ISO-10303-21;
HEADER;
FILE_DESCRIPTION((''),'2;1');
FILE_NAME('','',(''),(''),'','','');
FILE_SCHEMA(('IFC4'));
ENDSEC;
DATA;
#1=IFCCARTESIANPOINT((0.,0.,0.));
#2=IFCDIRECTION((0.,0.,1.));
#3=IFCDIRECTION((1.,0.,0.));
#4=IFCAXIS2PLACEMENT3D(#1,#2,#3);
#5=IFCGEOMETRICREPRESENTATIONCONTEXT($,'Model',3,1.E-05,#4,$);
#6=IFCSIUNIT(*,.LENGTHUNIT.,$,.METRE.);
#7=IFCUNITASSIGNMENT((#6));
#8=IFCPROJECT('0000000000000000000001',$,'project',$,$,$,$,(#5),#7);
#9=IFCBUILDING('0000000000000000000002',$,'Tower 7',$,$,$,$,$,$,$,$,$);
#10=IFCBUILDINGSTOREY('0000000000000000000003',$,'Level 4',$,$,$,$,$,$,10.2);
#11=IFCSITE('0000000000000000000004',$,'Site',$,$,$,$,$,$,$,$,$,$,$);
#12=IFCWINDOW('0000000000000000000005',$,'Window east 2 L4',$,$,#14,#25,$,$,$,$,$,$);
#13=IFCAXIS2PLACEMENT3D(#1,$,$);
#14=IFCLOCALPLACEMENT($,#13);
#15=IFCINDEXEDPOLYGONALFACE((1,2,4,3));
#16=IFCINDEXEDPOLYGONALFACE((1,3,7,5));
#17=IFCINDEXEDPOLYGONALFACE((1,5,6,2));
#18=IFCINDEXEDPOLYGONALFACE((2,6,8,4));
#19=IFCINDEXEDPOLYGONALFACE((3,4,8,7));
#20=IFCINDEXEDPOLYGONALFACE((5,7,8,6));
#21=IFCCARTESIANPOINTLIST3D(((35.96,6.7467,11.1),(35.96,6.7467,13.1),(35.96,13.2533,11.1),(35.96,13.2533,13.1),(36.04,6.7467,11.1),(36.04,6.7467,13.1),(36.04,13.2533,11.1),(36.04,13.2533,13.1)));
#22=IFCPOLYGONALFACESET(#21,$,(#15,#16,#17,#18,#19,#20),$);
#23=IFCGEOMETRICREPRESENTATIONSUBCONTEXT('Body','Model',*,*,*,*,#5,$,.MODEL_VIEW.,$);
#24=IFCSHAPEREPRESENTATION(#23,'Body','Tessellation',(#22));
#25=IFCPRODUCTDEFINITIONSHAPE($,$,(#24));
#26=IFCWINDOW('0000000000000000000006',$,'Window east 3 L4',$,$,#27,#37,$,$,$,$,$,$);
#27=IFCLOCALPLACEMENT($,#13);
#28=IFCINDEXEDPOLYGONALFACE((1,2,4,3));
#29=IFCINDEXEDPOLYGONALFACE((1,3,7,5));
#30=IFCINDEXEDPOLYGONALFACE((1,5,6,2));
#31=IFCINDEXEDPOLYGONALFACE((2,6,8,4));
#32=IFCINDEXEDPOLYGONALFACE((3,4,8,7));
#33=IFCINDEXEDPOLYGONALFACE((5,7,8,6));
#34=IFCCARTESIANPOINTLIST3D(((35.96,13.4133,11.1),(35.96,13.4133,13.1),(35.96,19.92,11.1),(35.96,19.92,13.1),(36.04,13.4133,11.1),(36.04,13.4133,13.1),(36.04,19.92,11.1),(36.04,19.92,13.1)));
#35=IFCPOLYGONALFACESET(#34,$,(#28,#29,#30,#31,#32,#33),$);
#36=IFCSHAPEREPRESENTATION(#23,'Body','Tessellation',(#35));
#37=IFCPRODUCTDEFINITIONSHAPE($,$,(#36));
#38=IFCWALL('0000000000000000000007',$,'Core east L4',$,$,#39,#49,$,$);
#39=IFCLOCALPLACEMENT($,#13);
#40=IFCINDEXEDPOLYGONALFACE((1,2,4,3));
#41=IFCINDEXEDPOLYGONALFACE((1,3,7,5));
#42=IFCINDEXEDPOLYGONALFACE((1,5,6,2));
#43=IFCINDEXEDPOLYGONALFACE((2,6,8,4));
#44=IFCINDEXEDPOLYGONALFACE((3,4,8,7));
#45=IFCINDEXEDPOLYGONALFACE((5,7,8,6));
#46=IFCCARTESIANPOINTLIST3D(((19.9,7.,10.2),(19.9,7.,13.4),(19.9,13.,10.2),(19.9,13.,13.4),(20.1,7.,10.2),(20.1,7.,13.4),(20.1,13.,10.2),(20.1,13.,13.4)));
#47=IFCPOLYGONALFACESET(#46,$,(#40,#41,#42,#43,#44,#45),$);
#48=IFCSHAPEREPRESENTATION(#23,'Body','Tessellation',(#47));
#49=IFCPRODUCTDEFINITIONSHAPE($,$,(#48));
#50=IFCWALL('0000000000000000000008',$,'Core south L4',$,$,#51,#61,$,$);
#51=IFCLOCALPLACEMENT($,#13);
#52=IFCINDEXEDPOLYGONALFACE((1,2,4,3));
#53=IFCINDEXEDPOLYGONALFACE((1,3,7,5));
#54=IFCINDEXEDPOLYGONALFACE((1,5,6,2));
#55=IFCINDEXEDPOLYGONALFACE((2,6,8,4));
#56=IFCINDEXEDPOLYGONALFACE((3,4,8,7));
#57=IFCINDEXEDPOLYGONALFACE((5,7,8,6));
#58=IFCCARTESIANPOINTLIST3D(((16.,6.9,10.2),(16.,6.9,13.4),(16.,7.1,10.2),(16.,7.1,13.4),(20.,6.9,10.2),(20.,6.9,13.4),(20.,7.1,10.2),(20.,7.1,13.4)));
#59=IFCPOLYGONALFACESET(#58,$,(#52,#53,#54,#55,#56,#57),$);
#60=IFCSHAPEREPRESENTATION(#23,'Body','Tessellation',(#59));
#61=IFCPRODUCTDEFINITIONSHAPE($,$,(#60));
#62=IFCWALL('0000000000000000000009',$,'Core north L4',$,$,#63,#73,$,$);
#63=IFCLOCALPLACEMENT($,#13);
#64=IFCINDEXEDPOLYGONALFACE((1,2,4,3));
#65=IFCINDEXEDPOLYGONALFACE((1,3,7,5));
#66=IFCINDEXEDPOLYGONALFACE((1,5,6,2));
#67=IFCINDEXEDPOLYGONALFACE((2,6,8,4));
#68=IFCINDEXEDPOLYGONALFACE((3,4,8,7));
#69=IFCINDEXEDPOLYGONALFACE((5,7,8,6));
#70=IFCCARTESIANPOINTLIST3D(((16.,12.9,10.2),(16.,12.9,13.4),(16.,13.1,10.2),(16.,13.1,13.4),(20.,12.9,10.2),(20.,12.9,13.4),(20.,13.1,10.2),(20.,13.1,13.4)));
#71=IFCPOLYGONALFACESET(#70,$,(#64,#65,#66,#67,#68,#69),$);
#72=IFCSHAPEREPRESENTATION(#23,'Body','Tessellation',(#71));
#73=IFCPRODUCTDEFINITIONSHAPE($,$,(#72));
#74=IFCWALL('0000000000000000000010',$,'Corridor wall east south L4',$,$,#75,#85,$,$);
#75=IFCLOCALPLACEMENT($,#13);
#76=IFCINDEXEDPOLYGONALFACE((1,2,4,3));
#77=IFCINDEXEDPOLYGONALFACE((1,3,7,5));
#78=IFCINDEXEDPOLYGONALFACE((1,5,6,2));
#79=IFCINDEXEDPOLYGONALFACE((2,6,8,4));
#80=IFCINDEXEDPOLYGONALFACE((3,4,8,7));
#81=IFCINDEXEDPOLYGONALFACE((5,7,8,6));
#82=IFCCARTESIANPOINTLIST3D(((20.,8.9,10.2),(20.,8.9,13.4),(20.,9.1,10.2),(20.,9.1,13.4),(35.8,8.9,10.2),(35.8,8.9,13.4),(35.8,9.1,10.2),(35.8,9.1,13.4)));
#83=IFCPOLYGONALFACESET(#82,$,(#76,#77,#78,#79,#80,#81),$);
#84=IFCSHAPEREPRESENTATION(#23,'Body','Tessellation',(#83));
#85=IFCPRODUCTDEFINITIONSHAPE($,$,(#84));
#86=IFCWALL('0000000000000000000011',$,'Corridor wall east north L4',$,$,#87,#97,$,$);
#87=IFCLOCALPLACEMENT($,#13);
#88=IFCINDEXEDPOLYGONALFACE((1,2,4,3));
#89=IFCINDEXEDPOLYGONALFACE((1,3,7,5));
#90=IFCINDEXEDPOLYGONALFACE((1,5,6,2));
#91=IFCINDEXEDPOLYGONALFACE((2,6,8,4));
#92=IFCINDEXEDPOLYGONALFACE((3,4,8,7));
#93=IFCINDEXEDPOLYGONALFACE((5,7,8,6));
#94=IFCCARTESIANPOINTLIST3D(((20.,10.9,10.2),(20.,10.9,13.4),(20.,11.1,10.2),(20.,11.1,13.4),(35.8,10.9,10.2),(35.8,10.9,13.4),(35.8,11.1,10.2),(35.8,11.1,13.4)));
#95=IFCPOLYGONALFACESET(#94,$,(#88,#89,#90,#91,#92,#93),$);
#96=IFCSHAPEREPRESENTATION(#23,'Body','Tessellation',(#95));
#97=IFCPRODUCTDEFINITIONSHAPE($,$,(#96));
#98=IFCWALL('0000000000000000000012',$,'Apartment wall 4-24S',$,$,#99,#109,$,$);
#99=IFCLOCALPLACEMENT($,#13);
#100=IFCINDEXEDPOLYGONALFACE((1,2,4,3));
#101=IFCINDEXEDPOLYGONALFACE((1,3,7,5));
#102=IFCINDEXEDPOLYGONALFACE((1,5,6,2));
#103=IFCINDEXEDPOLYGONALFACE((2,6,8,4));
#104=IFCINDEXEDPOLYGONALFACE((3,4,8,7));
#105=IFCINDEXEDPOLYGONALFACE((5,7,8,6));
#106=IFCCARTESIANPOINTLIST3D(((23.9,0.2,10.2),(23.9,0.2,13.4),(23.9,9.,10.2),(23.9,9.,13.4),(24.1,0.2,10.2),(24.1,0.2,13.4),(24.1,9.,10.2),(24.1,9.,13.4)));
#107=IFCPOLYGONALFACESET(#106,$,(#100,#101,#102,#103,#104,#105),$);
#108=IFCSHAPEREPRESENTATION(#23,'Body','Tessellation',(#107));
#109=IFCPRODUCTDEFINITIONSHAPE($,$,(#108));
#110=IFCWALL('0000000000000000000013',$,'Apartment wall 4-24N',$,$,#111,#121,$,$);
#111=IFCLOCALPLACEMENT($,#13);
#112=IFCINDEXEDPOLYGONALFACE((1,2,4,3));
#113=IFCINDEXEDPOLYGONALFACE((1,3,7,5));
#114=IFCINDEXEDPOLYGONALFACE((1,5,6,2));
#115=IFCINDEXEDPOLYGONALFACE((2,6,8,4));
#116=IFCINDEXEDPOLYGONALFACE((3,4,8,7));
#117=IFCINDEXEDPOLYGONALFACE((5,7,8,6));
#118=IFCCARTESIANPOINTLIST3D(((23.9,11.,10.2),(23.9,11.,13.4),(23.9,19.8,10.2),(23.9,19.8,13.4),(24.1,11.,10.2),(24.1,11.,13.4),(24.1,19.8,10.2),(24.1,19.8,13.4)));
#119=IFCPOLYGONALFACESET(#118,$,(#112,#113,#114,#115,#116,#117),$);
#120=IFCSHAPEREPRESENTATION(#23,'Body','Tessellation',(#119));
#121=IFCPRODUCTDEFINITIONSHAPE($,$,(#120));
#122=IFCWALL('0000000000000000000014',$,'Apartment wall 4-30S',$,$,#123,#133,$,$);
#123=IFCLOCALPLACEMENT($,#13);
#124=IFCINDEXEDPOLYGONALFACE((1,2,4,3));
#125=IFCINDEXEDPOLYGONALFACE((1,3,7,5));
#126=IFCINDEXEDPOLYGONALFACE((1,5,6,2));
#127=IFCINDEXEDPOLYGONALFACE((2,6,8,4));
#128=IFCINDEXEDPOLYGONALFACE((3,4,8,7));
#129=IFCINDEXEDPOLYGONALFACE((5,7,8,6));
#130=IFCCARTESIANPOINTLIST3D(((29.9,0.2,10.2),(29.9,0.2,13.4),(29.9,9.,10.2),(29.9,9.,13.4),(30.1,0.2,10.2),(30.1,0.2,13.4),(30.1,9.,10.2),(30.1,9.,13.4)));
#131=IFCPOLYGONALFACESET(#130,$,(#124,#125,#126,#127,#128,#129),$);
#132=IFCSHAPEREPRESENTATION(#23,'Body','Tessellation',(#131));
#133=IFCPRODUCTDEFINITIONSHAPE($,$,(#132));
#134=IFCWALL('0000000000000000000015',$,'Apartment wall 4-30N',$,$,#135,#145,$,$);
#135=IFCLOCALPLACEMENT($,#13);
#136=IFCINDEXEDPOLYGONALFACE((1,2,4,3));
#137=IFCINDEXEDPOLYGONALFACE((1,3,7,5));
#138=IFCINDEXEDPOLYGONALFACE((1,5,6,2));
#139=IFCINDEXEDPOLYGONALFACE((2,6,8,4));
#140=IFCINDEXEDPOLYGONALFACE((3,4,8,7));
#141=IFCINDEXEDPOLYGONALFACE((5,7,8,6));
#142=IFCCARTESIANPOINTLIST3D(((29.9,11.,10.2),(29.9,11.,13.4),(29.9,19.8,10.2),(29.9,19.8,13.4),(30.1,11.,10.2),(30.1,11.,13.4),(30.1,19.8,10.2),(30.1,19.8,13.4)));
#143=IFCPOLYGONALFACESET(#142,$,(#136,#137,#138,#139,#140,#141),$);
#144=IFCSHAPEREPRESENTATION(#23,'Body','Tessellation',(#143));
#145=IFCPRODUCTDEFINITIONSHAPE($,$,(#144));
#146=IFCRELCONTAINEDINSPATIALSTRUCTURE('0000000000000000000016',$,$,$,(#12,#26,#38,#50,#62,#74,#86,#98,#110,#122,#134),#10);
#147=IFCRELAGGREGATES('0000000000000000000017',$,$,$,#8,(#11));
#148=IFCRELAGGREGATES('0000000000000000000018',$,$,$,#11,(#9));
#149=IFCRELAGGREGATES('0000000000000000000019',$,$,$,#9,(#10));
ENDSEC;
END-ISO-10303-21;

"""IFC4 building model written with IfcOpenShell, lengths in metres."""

from ifc_helpers import new_model, si_unit, frame, origin, origin_with_axes, origin_2d, place, context, subcontext, project, spatial, rectangle, extrude, element, save


model = new_model("IFC4")

# Units and contexts
model_context = context("Model", 3, precision=1e-05, world=origin_with_axes())
body_context = subcontext(model_context, "Body", "Model", "MODEL_VIEW")
ifc_project = project(units=[si_unit("LENGTHUNIT", "METRE")], contexts=[model_context])

# Site, building, storey
site = spatial("IfcSite", under=ifc_project, Name="Site")
building = spatial("IfcBuilding", under=site, Name="Tower 7")
storey = spatial("IfcBuildingStorey", under=building, Name="Level 4", Elevation=10.2)

# Windows
for number, where, z_axis, x_axis, name in (
    (1, (36.0, 10.0, 11.1), (0.0, 0.0, 1.0), (1.0, 0.0, 0.0), "Window east 2 L4"),
):
    element("IfcWindow", number, at=place(None, frame(where, z_axis=z_axis, x_axis=x_axis)), inside=storey, Name=name, context=body_context, shape_type="SweptSolid", body=[
        extrude(rectangle(XDim=0.08, YDim=6.5067, at=origin_2d()), origin(), (0.0, 0.0, 1.0), 2.0),
    ])
window_placement = place(None, frame((36.0, 16.6667, 11.1), z_axis=(0.0, 0.0, 1.0), x_axis=(1.0, 0.0, 0.0)))
element("IfcWindow", 2, at=window_placement, inside=storey, Name="Window east 3 L4", context=body_context, shape_type="SweptSolid", body=[
    extrude(rectangle(XDim=0.08, YDim=6.5067, at=origin_2d()), origin(), (0.0, 0.0, 1.0), 2.0),
])

# Walls
wall_1_placement = place(None, frame((20.0, 10.0, 10.2), z_axis=(0.0, 0.0, 1.0), x_axis=(1.0, 0.0, 0.0)))
element("IfcWall", 3, at=wall_1_placement, inside=storey, Name="Core east L4", context=body_context, shape_type="SweptSolid", body=[
    extrude(rectangle(XDim=0.2, YDim=6.0, at=origin_2d()), origin(), (0.0, 0.0, 1.0), 3.2),
])
for number, where, z_axis, x_axis, name in (
    (4, (18.0, 7.0, 10.2), (0.0, 0.0, 1.0), (1.0, 0.0, 0.0), "Core south L4"),
    (5, (18.0, 13.0, 10.2), (0.0, 0.0, 1.0), (1.0, 0.0, 0.0), "Core north L4"),
):
    element("IfcWall", number, at=place(None, frame(where, z_axis=z_axis, x_axis=x_axis)), inside=storey, Name=name, context=body_context, shape_type="SweptSolid", body=[
        extrude(rectangle(XDim=4.0, YDim=0.2, at=origin_2d()), origin(), (0.0, 0.0, 1.0), 3.2),
    ])
for number, where, z_axis, x_axis, name in (
    (6, (27.9, 9.0, 10.2), (0.0, 0.0, 1.0), (1.0, 0.0, 0.0), "Corridor wall east south L4"),
    (7, (27.9, 11.0, 10.2), (0.0, 0.0, 1.0), (1.0, 0.0, 0.0), "Corridor wall east north L4"),
):
    element("IfcWall", number, at=place(None, frame(where, z_axis=z_axis, x_axis=x_axis)), inside=storey, Name=name, context=body_context, shape_type="SweptSolid", body=[
        extrude(rectangle(XDim=15.8, YDim=0.2, at=origin_2d()), origin(), (0.0, 0.0, 1.0), 3.2),
    ])
for number, where, z_axis, x_axis, name in (
    (8, (24.0, 4.6, 10.2), (0.0, 0.0, 1.0), (1.0, 0.0, 0.0), "Apartment wall 4-24S"),
    (9, (24.0, 15.4, 10.2), (0.0, 0.0, 1.0), (1.0, 0.0, 0.0), "Apartment wall 4-24N"),
    (10, (30.0, 4.6, 10.2), (0.0, 0.0, 1.0), (1.0, 0.0, 0.0), "Apartment wall 4-30S"),
    (11, (30.0, 15.4, 10.2), (0.0, 0.0, 1.0), (1.0, 0.0, 0.0), "Apartment wall 4-30N"),
):
    element("IfcWall", number, at=place(None, frame(where, z_axis=z_axis, x_axis=x_axis)), inside=storey, Name=name, context=body_context, shape_type="SweptSolid", body=[
        extrude(rectangle(XDim=0.2, YDim=8.8, at=origin_2d()), origin(), (0.0, 0.0, 1.0), 3.2),
    ])

save(model, "model.ifc")
